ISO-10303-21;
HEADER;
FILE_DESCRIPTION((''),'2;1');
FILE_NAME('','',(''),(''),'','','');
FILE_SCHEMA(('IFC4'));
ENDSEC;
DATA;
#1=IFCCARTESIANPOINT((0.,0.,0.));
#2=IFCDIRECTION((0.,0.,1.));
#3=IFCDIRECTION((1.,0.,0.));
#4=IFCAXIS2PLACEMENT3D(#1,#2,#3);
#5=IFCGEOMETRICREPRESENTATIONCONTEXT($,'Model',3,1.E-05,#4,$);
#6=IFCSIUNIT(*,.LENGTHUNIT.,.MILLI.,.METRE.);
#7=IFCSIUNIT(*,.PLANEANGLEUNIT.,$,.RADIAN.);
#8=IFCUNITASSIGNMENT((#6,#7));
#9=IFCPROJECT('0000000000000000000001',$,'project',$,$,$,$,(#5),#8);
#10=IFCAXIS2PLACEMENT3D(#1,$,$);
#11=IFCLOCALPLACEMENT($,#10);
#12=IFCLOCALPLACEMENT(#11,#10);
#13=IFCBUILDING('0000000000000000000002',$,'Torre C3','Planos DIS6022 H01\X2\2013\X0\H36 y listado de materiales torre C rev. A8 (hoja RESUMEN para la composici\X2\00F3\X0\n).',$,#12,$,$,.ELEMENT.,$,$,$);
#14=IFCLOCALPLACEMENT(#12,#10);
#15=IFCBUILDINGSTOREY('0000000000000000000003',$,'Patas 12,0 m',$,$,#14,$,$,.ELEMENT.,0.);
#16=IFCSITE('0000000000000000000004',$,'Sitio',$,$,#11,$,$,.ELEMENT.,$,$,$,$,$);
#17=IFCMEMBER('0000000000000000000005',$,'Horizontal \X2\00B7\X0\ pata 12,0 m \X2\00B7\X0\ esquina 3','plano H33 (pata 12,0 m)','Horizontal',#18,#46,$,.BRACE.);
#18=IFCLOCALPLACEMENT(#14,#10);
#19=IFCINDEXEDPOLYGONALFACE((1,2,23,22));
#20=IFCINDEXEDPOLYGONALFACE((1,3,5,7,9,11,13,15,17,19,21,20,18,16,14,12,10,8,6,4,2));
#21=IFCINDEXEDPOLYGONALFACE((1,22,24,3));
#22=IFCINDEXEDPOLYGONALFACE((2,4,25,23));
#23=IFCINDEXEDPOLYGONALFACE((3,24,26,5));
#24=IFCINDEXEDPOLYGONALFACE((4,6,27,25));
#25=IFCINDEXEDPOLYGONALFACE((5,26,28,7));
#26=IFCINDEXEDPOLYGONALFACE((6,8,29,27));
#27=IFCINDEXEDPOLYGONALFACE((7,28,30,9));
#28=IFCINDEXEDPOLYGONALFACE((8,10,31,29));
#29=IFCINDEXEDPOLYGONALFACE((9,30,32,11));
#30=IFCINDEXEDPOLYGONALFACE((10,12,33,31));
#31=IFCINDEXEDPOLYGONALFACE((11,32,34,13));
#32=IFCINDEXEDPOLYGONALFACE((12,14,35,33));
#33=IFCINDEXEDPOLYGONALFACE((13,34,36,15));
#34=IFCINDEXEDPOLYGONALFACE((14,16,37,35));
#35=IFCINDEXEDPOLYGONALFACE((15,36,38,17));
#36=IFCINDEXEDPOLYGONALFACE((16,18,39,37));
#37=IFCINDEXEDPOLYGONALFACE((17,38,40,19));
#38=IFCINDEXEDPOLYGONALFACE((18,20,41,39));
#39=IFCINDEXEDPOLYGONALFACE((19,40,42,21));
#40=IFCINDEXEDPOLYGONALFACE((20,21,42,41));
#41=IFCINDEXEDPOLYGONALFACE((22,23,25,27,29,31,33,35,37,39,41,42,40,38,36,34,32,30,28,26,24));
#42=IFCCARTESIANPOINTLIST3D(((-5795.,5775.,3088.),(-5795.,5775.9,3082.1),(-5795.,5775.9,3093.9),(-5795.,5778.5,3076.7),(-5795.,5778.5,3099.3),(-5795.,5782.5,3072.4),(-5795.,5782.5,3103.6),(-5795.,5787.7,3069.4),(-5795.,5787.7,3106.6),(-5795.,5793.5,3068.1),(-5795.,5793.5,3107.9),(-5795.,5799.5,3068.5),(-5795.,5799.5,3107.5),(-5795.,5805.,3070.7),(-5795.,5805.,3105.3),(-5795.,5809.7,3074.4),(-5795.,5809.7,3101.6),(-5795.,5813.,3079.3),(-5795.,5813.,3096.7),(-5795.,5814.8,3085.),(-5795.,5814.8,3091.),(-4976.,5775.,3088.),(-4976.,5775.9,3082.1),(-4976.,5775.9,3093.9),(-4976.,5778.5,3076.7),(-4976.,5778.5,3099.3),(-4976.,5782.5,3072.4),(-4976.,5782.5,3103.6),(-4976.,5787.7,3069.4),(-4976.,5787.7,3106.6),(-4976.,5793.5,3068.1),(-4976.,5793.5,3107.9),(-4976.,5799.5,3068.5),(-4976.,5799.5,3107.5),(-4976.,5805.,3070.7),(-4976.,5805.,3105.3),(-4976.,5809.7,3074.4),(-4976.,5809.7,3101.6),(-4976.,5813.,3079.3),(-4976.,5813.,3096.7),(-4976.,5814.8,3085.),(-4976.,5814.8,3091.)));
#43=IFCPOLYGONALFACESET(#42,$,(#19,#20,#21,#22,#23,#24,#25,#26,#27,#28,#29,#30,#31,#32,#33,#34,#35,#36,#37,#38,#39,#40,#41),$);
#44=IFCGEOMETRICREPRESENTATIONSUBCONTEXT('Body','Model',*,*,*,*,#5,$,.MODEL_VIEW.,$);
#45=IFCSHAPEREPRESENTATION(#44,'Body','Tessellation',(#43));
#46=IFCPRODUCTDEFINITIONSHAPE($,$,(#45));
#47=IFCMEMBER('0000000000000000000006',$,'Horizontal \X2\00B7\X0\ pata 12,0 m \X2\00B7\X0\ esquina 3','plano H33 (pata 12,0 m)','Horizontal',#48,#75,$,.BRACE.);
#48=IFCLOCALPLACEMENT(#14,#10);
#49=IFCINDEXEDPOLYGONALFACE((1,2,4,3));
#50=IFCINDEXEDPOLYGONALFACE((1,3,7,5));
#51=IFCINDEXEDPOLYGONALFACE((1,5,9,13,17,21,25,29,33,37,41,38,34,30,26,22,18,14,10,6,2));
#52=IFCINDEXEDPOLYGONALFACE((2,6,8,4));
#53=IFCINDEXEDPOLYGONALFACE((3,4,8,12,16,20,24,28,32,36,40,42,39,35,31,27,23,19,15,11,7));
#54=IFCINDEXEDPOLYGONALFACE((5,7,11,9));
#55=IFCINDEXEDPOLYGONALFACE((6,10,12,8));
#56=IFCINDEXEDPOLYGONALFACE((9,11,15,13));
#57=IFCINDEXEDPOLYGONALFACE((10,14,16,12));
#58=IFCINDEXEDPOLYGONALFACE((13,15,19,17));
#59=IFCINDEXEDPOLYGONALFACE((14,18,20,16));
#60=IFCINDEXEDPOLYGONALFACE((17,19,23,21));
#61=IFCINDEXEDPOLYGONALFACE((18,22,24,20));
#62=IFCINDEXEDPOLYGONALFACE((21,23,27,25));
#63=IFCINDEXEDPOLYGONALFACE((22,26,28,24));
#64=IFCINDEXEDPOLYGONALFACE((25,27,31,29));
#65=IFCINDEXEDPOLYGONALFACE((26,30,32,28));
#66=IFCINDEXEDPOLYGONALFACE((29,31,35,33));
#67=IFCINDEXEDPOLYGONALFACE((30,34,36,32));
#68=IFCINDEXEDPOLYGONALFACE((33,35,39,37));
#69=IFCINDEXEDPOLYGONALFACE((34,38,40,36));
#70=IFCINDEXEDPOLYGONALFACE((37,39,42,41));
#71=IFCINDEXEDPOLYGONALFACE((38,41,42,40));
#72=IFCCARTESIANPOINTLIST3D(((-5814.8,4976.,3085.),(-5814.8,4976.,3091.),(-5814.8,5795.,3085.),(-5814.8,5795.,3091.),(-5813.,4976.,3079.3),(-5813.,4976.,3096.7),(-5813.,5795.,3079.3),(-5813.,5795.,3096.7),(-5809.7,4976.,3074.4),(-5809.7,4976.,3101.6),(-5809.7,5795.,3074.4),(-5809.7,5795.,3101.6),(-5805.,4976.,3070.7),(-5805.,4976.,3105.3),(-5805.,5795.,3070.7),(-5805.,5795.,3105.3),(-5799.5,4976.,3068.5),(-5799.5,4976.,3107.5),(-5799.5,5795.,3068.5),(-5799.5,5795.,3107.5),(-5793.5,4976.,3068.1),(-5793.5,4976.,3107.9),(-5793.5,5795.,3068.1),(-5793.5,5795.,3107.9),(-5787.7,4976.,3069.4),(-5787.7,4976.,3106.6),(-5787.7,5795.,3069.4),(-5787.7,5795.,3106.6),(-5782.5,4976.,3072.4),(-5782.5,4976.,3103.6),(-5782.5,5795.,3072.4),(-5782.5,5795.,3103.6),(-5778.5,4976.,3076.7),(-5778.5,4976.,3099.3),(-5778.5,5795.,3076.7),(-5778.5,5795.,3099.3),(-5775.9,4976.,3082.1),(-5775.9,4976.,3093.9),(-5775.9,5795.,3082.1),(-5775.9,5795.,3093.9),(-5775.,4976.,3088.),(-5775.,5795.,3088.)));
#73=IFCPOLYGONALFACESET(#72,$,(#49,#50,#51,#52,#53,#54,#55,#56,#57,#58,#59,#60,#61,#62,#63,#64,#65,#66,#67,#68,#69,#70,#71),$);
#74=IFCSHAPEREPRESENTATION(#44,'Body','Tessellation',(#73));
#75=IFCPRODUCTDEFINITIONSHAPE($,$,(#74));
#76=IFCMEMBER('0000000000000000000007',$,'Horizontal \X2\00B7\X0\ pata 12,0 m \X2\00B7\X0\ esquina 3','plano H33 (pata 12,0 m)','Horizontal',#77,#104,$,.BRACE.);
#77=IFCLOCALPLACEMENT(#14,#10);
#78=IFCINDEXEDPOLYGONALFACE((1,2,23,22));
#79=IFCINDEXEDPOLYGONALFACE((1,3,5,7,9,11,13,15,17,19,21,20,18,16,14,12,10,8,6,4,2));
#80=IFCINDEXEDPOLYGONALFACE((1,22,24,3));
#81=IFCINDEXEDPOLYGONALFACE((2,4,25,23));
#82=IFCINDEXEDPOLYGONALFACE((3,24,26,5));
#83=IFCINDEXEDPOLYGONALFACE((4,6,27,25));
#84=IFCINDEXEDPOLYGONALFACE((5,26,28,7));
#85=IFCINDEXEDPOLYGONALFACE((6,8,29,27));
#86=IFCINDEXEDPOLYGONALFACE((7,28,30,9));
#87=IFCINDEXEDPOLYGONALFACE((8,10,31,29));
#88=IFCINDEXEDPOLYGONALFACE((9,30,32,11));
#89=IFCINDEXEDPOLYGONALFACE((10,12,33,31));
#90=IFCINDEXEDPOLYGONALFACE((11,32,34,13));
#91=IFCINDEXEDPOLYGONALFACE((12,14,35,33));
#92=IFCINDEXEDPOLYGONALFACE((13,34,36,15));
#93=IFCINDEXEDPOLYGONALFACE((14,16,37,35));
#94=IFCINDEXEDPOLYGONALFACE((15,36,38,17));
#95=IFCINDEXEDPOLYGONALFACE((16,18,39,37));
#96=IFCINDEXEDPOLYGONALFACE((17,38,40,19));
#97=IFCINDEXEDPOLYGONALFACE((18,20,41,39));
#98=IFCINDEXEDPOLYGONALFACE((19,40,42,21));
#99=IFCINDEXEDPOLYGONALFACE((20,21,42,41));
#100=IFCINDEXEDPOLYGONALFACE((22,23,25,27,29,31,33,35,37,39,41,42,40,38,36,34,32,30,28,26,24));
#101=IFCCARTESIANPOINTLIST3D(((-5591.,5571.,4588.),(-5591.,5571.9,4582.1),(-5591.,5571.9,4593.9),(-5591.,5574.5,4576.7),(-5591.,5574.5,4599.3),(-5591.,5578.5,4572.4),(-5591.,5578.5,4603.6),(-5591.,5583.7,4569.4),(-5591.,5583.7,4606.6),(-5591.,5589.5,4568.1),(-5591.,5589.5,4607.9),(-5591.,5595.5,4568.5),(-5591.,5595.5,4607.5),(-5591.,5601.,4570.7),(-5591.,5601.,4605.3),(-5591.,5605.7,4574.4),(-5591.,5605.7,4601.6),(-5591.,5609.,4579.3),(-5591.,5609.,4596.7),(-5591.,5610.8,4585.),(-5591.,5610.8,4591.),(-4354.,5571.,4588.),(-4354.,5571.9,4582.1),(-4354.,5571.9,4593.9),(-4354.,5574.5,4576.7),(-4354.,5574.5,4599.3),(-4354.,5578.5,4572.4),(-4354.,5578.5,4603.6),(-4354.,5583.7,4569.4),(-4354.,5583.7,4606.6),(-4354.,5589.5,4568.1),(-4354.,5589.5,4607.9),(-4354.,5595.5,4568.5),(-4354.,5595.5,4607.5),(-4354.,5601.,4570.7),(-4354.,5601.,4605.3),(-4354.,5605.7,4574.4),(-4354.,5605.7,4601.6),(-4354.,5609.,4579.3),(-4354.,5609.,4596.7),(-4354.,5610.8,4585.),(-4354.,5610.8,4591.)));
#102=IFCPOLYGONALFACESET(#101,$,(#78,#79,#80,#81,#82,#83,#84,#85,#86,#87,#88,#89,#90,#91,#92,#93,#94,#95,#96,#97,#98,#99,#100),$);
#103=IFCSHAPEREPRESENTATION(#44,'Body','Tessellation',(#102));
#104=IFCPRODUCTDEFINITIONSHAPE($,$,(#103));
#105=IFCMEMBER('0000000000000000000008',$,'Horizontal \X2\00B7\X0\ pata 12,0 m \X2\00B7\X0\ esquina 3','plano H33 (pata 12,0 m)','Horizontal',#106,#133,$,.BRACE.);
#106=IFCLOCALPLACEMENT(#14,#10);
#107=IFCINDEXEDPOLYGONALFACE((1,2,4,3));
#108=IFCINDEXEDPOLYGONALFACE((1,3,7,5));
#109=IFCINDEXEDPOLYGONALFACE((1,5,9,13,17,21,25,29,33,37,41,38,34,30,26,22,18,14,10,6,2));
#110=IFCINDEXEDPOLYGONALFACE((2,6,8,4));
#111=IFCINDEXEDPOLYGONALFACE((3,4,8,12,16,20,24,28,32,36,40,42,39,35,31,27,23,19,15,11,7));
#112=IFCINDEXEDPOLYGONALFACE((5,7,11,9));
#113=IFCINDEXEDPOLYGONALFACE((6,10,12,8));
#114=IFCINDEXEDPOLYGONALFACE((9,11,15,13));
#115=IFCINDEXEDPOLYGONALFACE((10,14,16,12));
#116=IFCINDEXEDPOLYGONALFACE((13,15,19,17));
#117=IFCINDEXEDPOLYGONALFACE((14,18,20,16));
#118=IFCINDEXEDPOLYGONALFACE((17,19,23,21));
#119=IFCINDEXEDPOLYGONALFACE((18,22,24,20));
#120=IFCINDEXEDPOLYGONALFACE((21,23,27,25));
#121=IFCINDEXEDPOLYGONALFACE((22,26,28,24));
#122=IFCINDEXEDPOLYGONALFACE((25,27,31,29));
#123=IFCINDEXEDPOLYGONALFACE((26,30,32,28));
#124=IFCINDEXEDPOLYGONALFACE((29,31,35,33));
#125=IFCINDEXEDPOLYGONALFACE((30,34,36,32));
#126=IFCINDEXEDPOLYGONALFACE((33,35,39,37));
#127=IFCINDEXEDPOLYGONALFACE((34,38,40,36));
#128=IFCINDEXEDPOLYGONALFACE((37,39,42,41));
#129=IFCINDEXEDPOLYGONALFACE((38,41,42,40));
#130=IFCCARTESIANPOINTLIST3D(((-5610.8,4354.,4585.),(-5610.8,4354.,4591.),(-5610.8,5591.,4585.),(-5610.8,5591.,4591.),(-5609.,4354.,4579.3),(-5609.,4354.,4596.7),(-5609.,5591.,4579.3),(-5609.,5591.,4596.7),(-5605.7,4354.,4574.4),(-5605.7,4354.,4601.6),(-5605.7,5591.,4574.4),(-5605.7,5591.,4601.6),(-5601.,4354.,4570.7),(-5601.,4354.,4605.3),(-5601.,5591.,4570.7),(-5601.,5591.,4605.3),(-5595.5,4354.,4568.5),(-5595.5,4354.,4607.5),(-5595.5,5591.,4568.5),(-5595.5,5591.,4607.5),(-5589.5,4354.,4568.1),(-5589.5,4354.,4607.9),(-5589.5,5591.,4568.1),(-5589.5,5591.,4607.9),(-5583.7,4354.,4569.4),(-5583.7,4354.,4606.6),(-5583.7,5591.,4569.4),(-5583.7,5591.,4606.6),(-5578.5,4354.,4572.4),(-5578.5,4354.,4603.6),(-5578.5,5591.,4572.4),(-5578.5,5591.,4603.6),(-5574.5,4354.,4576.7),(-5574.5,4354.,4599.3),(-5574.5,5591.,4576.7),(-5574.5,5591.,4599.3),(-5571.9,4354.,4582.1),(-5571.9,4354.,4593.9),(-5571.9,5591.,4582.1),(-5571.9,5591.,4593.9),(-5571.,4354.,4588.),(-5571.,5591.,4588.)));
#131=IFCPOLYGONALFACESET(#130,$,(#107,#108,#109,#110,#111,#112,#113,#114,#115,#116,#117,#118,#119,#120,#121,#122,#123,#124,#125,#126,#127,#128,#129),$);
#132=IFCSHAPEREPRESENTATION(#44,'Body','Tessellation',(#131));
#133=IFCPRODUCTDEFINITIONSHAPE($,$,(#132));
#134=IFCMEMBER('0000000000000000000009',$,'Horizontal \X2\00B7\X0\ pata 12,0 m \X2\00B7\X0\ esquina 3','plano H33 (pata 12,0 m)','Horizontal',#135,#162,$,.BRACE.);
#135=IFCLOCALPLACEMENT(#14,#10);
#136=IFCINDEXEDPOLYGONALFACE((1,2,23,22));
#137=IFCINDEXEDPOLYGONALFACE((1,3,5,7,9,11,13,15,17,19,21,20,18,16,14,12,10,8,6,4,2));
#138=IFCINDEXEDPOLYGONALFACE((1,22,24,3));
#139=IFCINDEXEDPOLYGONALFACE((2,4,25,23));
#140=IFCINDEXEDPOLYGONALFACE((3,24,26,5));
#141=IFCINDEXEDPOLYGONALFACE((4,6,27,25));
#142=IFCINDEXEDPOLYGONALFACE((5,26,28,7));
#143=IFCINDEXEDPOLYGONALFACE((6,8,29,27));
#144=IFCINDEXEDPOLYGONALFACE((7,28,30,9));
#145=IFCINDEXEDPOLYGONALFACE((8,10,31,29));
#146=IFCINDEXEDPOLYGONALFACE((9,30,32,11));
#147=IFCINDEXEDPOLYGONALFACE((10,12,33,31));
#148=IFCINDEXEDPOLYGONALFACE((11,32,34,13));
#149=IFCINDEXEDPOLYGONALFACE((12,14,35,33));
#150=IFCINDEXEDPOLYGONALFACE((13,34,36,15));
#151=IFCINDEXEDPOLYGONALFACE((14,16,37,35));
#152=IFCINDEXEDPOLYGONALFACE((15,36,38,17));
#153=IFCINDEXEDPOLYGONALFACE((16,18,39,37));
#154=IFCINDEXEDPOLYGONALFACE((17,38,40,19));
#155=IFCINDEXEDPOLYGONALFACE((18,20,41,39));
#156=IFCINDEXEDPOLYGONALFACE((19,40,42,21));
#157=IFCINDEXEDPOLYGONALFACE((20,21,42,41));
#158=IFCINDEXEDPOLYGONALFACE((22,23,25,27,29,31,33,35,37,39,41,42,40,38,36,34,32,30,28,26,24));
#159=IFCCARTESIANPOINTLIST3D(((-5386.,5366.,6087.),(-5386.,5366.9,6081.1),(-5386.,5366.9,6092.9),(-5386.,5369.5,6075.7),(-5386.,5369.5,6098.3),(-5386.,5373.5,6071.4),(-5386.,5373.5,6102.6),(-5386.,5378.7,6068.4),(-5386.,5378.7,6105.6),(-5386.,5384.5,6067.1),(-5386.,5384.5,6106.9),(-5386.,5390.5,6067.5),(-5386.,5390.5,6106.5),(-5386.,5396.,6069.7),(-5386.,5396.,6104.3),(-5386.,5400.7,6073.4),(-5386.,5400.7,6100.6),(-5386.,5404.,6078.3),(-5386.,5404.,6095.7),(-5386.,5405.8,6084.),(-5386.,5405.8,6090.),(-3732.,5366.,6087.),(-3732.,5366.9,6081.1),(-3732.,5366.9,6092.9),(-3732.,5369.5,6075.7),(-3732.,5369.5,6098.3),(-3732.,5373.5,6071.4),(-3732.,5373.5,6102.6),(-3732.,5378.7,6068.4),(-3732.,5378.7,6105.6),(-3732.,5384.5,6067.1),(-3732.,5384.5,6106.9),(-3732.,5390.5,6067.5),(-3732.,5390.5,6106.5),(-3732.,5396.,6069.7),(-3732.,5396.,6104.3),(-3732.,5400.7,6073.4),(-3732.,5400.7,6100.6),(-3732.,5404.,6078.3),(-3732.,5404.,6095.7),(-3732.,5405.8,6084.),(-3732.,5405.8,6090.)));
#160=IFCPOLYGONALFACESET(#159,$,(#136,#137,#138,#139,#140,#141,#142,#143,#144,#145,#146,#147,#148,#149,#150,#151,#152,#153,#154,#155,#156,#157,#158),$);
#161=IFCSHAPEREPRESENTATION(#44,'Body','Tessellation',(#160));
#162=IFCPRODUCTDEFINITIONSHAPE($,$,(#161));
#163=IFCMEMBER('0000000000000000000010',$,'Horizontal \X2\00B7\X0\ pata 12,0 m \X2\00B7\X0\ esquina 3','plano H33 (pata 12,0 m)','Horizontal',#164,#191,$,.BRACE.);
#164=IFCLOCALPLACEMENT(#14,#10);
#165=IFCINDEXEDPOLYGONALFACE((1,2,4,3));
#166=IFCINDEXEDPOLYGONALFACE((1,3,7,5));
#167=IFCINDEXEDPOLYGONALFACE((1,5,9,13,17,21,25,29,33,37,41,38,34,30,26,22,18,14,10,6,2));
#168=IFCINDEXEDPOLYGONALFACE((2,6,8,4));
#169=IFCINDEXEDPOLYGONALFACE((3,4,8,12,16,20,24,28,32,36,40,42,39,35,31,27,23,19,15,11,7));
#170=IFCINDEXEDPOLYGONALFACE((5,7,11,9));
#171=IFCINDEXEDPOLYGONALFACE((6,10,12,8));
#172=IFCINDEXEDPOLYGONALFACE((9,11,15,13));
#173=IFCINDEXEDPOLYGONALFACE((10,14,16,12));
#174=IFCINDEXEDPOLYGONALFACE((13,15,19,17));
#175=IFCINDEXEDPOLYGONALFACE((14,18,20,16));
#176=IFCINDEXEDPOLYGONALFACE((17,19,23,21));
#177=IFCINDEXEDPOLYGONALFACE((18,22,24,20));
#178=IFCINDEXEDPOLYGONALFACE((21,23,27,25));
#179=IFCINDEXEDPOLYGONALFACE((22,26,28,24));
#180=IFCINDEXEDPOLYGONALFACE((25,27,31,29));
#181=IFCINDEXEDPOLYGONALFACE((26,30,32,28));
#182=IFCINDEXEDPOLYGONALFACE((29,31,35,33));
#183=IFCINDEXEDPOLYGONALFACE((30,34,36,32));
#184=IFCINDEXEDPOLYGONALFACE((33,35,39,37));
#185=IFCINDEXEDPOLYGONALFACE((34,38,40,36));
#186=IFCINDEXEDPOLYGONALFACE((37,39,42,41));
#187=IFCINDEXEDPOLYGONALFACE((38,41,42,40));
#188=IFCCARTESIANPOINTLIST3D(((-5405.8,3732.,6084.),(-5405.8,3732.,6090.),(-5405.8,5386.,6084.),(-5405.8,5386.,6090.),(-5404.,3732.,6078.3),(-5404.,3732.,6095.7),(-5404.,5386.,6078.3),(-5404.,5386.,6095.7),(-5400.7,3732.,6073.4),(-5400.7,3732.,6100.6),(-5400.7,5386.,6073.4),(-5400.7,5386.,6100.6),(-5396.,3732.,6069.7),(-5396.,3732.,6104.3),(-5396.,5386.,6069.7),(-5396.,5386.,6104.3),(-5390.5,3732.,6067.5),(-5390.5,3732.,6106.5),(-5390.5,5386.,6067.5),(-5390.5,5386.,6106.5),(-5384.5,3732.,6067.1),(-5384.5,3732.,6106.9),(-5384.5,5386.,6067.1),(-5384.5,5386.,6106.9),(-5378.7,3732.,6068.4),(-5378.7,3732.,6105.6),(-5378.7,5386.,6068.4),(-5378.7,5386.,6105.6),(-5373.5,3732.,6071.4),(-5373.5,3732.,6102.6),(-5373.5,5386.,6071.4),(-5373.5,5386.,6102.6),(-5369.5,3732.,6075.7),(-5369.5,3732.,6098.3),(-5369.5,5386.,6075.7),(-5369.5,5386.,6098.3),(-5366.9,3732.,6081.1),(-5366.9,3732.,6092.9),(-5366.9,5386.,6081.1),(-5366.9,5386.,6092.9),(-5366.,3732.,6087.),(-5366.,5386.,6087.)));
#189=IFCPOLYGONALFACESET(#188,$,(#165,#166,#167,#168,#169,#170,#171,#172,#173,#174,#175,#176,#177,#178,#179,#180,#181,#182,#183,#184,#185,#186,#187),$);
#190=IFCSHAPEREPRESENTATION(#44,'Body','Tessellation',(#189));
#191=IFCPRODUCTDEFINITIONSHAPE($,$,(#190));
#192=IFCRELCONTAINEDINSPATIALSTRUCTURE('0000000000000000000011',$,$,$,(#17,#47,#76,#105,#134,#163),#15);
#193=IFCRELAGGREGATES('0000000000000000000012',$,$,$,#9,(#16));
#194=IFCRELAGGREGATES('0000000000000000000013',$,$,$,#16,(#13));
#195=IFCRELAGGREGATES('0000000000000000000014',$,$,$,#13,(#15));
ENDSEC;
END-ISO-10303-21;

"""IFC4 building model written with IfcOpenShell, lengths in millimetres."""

from ifc_helpers import new_model, si_unit, frame, origin, origin_with_axes, place, context, subcontext, project, spatial, circle, extrude, element, save


model = new_model("IFC4")

# Units and contexts
model_context = context("Model", 3, precision=1e-05, world=origin_with_axes())
body_context = subcontext(model_context, "Body", "Model", "MODEL_VIEW")
ifc_project = project(units=[si_unit("LENGTHUNIT", "METRE", prefix="MILLI"), si_unit("PLANEANGLEUNIT", "RADIAN")], contexts=[model_context])

# Site, building, storey
site_placement = place(None, origin())
site = spatial("IfcSite", under=ifc_project, at=site_placement, Name="Sitio", CompositionType="ELEMENT")
building_placement = place(site_placement, origin())
building = spatial("IfcBuilding", under=site, at=building_placement, Name="Torre C3", Description="Planos DIS6022 H01–H36 y listado de materiales torre C rev. A8 (hoja RESUMEN para la composición).", CompositionType="ELEMENT")
storey_placement = place(building_placement, origin())
storey = spatial("IfcBuildingStorey", under=building, at=storey_placement, Name="Patas 12,0 m", CompositionType="ELEMENT", Elevation=0.0)

# Members
for number, where, z_axis, x_axis, name in (
    (1, (-5795.0, 5795.0, 3088.0), (1.0, 0.0, 0.0), (0.0, -1.0, 0.0), "Horizontal · pata 12,0 m · esquina 3"),
    (2, (-5795.0, 5795.0, 3088.0), (0.0, -1.0, 0.0), (1.0, 0.0, 0.0), "Horizontal · pata 12,0 m · esquina 3"),
):
    element("IfcMember", number, at=place(storey_placement, frame(where, z_axis=z_axis, x_axis=x_axis)), inside=storey, Name=name, Description="plano H33 (pata 12,0 m)", ObjectType="Horizontal", PredefinedType="BRACE", context=body_context, shape_type="SweptSolid", body=[
        extrude(circle(Radius=20.0), None, (0.0, 0.0, 1.0), 819.0),
    ])
for number, where, z_axis, x_axis, name in (
    (3, (-5591.0, 5591.0, 4588.0), (1.0, 0.0, 0.0), (0.0, -1.0, 0.0), "Horizontal · pata 12,0 m · esquina 3"),
    (4, (-5591.0, 5591.0, 4588.0), (0.0, -1.0, 0.0), (1.0, 0.0, 0.0), "Horizontal · pata 12,0 m · esquina 3"),
):
    element("IfcMember", number, at=place(storey_placement, frame(where, z_axis=z_axis, x_axis=x_axis)), inside=storey, Name=name, Description="plano H33 (pata 12,0 m)", ObjectType="Horizontal", PredefinedType="BRACE", context=body_context, shape_type="SweptSolid", body=[
        extrude(circle(Radius=20.0), None, (0.0, 0.0, 1.0), 1237.0),
    ])
for number, where, z_axis, x_axis, name in (
    (5, (-3732.0, 5386.0, 6087.0), (-1.0, 0.0, 0.0), (0.0, -1.0, 0.0), "Horizontal · pata 12,0 m · esquina 3"),
    (6, (-5386.0, 3732.0, 6087.0), (0.0, 1.0, 0.0), (1.0, 0.0, 0.0), "Horizontal · pata 12,0 m · esquina 3"),
):
    element("IfcMember", number, at=place(storey_placement, frame(where, z_axis=z_axis, x_axis=x_axis)), inside=storey, Name=name, Description="plano H33 (pata 12,0 m)", ObjectType="Horizontal", PredefinedType="BRACE", context=body_context, shape_type="SweptSolid", body=[
        extrude(circle(Radius=20.0), None, (0.0, 0.0, 1.0), 1654.0),
    ])

save(model, "model.ifc")
